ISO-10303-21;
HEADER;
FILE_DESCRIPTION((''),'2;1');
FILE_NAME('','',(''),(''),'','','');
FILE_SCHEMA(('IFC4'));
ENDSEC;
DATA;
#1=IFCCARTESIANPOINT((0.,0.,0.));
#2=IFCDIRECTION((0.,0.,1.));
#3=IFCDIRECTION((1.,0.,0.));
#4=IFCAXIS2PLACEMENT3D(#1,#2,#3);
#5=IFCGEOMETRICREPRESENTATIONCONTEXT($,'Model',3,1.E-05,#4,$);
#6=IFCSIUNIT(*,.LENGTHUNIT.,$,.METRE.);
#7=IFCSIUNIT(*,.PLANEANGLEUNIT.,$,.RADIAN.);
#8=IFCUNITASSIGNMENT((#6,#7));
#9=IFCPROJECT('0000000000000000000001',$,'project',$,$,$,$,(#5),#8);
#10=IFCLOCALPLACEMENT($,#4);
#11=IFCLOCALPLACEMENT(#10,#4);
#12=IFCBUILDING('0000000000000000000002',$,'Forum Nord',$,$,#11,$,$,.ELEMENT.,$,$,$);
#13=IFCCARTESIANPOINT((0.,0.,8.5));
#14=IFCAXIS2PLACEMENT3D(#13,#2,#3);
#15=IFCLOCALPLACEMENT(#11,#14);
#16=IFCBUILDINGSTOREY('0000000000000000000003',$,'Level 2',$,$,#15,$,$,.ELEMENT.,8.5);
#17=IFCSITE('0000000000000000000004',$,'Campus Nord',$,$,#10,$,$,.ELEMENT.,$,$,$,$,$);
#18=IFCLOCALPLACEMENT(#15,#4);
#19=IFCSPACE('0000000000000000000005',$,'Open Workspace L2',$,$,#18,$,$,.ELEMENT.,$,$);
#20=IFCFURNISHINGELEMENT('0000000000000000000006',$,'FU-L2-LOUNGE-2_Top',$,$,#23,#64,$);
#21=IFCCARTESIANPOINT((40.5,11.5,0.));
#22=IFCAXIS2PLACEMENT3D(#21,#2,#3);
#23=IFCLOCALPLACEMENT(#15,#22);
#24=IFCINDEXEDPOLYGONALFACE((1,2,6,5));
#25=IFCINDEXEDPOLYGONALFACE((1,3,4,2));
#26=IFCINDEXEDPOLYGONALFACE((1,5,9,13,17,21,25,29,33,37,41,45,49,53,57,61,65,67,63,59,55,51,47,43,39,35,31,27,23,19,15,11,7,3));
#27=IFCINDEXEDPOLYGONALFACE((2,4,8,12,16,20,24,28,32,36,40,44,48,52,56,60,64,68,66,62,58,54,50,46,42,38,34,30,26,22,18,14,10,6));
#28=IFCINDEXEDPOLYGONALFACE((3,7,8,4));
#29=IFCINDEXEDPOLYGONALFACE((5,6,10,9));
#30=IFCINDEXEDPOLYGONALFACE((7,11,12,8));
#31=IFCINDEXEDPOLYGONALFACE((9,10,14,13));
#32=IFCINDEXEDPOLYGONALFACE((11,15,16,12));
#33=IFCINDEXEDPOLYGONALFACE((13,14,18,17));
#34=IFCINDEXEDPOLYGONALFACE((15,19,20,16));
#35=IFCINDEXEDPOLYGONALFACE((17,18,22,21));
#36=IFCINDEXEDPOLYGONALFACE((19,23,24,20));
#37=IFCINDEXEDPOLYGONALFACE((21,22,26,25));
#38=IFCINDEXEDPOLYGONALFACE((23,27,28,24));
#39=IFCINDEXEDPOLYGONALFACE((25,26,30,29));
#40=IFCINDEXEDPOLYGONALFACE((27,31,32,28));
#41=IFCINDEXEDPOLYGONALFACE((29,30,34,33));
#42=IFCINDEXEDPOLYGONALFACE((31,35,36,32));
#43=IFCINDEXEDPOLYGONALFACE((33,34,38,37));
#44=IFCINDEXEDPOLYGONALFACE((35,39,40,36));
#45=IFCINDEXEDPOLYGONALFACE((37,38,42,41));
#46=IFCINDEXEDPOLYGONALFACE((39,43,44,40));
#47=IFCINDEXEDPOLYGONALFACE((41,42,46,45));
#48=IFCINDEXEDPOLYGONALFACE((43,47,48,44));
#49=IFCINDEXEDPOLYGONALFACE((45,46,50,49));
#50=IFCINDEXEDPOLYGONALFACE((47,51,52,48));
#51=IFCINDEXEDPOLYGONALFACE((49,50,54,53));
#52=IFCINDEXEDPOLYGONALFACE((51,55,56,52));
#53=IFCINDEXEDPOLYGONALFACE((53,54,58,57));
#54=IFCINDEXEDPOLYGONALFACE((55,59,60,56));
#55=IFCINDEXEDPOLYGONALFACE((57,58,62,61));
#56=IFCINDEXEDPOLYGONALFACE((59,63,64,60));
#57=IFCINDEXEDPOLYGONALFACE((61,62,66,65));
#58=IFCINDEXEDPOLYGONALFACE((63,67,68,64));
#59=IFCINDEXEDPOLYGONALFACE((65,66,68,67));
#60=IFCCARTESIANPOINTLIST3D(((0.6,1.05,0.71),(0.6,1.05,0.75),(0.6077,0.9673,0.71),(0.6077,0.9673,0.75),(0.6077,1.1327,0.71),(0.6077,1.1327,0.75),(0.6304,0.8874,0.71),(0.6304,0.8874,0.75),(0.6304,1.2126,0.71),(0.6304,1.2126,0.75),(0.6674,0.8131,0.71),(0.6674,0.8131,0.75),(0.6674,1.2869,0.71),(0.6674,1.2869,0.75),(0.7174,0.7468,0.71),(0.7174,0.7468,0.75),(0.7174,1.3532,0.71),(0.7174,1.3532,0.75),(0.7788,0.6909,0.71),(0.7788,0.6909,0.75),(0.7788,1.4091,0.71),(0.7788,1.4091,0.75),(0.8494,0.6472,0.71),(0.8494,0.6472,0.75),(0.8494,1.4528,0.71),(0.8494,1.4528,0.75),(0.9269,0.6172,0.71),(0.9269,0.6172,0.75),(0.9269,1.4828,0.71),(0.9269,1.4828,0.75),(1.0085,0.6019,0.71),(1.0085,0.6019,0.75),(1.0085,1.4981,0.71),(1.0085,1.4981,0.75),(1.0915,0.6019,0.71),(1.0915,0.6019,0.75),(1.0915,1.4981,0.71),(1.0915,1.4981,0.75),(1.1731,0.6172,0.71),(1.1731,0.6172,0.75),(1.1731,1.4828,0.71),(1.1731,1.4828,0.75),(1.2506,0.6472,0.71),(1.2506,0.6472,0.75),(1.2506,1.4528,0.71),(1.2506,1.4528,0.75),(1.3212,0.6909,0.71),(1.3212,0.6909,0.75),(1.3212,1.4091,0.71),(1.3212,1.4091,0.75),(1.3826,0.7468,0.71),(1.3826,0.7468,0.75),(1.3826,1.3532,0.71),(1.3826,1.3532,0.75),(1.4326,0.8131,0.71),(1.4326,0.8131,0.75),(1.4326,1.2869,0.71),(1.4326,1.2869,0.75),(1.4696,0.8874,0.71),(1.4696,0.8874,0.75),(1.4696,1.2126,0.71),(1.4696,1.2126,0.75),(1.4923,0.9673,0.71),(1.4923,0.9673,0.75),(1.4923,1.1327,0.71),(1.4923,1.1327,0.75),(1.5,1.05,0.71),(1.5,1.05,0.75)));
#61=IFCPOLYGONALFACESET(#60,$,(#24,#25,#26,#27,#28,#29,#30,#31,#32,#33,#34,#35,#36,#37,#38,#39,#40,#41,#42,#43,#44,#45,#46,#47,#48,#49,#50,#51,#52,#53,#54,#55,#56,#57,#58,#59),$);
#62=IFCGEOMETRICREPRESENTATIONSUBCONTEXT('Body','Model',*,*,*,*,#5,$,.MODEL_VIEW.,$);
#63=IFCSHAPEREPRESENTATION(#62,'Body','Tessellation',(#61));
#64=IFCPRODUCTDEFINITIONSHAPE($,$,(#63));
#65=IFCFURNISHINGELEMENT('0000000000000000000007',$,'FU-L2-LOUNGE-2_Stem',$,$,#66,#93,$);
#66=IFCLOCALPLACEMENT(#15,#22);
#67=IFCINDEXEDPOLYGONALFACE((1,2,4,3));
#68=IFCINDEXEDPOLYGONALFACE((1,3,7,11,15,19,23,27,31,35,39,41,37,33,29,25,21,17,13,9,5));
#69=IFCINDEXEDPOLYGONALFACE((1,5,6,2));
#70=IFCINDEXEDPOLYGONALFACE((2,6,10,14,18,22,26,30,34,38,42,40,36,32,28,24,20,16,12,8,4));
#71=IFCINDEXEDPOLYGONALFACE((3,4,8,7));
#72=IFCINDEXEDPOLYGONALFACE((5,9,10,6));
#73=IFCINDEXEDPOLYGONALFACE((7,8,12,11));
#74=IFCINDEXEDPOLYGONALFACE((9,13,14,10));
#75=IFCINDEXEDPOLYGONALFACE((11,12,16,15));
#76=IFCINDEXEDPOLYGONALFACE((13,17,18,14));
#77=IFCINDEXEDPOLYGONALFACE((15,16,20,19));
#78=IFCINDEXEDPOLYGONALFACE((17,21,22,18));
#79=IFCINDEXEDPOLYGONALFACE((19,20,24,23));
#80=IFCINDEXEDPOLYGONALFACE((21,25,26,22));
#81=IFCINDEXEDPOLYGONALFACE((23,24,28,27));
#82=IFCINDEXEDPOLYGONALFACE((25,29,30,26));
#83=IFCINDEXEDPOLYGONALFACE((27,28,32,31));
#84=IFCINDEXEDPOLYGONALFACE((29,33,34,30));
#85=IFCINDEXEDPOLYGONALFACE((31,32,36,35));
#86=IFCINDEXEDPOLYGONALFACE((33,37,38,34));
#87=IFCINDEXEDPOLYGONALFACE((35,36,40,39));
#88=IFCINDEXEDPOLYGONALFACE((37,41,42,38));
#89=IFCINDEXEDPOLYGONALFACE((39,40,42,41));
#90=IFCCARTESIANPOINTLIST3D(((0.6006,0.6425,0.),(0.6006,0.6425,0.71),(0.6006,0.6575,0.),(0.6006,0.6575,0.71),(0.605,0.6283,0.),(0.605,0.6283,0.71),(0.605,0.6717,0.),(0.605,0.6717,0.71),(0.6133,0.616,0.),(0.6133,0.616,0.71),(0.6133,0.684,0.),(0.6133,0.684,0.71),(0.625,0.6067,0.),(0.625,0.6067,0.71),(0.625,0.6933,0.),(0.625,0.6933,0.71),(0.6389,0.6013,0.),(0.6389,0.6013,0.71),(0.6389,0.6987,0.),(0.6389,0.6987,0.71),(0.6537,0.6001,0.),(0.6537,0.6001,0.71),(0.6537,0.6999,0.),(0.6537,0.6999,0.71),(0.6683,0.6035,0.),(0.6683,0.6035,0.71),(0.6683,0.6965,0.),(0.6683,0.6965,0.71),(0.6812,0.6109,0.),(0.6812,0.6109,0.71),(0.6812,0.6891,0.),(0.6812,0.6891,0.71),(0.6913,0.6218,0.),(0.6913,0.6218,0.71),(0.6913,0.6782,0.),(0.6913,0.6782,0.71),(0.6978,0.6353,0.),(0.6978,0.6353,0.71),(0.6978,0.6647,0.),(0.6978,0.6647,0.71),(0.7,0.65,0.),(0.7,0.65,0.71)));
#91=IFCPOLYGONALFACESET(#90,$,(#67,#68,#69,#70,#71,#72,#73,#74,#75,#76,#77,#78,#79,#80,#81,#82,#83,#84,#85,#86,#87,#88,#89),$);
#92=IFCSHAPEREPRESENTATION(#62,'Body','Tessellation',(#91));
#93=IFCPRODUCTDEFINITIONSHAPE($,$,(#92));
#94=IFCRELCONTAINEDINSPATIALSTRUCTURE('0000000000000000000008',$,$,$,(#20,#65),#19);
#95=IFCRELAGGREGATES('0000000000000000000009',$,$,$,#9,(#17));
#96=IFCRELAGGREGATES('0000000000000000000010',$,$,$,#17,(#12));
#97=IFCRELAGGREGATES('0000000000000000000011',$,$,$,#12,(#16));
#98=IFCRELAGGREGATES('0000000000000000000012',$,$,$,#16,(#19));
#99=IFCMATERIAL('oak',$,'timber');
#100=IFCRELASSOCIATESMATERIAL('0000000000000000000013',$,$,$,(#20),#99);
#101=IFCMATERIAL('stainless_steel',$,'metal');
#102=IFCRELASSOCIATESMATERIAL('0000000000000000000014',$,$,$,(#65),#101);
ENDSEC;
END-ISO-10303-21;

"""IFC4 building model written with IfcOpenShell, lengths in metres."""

from ifc_helpers import new_model, si_unit, frame, frame_2d, origin_with_axes, place, context, subcontext, project, spatial, circle, extrude, material, element, save


model = new_model("IFC4")

# Units and contexts
model_context = context("Model", 3, precision=1e-05, world=origin_with_axes())
body_context = subcontext(model_context, "Body", "Model", "MODEL_VIEW")
ifc_project = project(units=[si_unit("LENGTHUNIT", "METRE"), si_unit("PLANEANGLEUNIT", "RADIAN")], contexts=[model_context])

# Site, building, storey
site_placement = place(None, origin_with_axes())
site = spatial("IfcSite", under=ifc_project, at=site_placement, Name="Campus Nord", CompositionType="ELEMENT")
building_placement = place(site_placement, origin_with_axes())
building = spatial("IfcBuilding", under=site, at=building_placement, Name="Forum Nord", CompositionType="ELEMENT")
storey_placement = place(building_placement, frame((0.0, 0.0, 8.5), z_axis=(0.0, 0.0, 1.0), x_axis=(1.0, 0.0, 0.0)))
storey = spatial("IfcBuildingStorey", under=building, at=storey_placement, Name="Level 2", CompositionType="ELEMENT", Elevation=8.5)

# Shared definitions
ifc_material_1 = material(Name="stainless_steel", Category="metal")

# Shared definitions
space_placement = place(storey_placement, origin_with_axes())
space = spatial("IfcSpace", under=storey, at=space_placement, Name="Open Workspace L2", CompositionType="ELEMENT")

# Furnishing elements
ifc_material_2 = material(Name="oak", Category="timber")
furnishing_1_placement = place(storey_placement, frame((40.5, 11.5, 0.0), z_axis=(0.0, 0.0, 1.0), x_axis=(1.0, 0.0, 0.0)))
element("IfcFurnishingElement", 1, at=furnishing_1_placement, inside=space, material=ifc_material_2, Name="FU-L2-LOUNGE-2_Top", context=body_context, shape_type="SweptSolid", body=[
    extrude(circle(Radius=0.45, at=frame_2d((1.05, 1.05), x_axis=(1.0, 0.0))), frame((0.0, 0.0, 0.71), z_axis=(0.0, 0.0, 1.0), x_axis=(1.0, 0.0, 0.0)), (0.0, 0.0, 1.0), 0.04),
])
furnishing_2_placement = place(storey_placement, frame((40.5, 11.5, 0.0), z_axis=(0.0, 0.0, 1.0), x_axis=(1.0, 0.0, 0.0)))
element("IfcFurnishingElement", 2, at=furnishing_2_placement, inside=space, material=ifc_material_1, Name="FU-L2-LOUNGE-2_Stem", context=body_context, shape_type="SweptSolid", body=[
    extrude(circle(Radius=0.05, at=frame_2d((0.65, 0.65), x_axis=(1.0, 0.0))), origin_with_axes(), (0.0, 0.0, 1.0), 0.71),
])

save(model, "model.ifc")
